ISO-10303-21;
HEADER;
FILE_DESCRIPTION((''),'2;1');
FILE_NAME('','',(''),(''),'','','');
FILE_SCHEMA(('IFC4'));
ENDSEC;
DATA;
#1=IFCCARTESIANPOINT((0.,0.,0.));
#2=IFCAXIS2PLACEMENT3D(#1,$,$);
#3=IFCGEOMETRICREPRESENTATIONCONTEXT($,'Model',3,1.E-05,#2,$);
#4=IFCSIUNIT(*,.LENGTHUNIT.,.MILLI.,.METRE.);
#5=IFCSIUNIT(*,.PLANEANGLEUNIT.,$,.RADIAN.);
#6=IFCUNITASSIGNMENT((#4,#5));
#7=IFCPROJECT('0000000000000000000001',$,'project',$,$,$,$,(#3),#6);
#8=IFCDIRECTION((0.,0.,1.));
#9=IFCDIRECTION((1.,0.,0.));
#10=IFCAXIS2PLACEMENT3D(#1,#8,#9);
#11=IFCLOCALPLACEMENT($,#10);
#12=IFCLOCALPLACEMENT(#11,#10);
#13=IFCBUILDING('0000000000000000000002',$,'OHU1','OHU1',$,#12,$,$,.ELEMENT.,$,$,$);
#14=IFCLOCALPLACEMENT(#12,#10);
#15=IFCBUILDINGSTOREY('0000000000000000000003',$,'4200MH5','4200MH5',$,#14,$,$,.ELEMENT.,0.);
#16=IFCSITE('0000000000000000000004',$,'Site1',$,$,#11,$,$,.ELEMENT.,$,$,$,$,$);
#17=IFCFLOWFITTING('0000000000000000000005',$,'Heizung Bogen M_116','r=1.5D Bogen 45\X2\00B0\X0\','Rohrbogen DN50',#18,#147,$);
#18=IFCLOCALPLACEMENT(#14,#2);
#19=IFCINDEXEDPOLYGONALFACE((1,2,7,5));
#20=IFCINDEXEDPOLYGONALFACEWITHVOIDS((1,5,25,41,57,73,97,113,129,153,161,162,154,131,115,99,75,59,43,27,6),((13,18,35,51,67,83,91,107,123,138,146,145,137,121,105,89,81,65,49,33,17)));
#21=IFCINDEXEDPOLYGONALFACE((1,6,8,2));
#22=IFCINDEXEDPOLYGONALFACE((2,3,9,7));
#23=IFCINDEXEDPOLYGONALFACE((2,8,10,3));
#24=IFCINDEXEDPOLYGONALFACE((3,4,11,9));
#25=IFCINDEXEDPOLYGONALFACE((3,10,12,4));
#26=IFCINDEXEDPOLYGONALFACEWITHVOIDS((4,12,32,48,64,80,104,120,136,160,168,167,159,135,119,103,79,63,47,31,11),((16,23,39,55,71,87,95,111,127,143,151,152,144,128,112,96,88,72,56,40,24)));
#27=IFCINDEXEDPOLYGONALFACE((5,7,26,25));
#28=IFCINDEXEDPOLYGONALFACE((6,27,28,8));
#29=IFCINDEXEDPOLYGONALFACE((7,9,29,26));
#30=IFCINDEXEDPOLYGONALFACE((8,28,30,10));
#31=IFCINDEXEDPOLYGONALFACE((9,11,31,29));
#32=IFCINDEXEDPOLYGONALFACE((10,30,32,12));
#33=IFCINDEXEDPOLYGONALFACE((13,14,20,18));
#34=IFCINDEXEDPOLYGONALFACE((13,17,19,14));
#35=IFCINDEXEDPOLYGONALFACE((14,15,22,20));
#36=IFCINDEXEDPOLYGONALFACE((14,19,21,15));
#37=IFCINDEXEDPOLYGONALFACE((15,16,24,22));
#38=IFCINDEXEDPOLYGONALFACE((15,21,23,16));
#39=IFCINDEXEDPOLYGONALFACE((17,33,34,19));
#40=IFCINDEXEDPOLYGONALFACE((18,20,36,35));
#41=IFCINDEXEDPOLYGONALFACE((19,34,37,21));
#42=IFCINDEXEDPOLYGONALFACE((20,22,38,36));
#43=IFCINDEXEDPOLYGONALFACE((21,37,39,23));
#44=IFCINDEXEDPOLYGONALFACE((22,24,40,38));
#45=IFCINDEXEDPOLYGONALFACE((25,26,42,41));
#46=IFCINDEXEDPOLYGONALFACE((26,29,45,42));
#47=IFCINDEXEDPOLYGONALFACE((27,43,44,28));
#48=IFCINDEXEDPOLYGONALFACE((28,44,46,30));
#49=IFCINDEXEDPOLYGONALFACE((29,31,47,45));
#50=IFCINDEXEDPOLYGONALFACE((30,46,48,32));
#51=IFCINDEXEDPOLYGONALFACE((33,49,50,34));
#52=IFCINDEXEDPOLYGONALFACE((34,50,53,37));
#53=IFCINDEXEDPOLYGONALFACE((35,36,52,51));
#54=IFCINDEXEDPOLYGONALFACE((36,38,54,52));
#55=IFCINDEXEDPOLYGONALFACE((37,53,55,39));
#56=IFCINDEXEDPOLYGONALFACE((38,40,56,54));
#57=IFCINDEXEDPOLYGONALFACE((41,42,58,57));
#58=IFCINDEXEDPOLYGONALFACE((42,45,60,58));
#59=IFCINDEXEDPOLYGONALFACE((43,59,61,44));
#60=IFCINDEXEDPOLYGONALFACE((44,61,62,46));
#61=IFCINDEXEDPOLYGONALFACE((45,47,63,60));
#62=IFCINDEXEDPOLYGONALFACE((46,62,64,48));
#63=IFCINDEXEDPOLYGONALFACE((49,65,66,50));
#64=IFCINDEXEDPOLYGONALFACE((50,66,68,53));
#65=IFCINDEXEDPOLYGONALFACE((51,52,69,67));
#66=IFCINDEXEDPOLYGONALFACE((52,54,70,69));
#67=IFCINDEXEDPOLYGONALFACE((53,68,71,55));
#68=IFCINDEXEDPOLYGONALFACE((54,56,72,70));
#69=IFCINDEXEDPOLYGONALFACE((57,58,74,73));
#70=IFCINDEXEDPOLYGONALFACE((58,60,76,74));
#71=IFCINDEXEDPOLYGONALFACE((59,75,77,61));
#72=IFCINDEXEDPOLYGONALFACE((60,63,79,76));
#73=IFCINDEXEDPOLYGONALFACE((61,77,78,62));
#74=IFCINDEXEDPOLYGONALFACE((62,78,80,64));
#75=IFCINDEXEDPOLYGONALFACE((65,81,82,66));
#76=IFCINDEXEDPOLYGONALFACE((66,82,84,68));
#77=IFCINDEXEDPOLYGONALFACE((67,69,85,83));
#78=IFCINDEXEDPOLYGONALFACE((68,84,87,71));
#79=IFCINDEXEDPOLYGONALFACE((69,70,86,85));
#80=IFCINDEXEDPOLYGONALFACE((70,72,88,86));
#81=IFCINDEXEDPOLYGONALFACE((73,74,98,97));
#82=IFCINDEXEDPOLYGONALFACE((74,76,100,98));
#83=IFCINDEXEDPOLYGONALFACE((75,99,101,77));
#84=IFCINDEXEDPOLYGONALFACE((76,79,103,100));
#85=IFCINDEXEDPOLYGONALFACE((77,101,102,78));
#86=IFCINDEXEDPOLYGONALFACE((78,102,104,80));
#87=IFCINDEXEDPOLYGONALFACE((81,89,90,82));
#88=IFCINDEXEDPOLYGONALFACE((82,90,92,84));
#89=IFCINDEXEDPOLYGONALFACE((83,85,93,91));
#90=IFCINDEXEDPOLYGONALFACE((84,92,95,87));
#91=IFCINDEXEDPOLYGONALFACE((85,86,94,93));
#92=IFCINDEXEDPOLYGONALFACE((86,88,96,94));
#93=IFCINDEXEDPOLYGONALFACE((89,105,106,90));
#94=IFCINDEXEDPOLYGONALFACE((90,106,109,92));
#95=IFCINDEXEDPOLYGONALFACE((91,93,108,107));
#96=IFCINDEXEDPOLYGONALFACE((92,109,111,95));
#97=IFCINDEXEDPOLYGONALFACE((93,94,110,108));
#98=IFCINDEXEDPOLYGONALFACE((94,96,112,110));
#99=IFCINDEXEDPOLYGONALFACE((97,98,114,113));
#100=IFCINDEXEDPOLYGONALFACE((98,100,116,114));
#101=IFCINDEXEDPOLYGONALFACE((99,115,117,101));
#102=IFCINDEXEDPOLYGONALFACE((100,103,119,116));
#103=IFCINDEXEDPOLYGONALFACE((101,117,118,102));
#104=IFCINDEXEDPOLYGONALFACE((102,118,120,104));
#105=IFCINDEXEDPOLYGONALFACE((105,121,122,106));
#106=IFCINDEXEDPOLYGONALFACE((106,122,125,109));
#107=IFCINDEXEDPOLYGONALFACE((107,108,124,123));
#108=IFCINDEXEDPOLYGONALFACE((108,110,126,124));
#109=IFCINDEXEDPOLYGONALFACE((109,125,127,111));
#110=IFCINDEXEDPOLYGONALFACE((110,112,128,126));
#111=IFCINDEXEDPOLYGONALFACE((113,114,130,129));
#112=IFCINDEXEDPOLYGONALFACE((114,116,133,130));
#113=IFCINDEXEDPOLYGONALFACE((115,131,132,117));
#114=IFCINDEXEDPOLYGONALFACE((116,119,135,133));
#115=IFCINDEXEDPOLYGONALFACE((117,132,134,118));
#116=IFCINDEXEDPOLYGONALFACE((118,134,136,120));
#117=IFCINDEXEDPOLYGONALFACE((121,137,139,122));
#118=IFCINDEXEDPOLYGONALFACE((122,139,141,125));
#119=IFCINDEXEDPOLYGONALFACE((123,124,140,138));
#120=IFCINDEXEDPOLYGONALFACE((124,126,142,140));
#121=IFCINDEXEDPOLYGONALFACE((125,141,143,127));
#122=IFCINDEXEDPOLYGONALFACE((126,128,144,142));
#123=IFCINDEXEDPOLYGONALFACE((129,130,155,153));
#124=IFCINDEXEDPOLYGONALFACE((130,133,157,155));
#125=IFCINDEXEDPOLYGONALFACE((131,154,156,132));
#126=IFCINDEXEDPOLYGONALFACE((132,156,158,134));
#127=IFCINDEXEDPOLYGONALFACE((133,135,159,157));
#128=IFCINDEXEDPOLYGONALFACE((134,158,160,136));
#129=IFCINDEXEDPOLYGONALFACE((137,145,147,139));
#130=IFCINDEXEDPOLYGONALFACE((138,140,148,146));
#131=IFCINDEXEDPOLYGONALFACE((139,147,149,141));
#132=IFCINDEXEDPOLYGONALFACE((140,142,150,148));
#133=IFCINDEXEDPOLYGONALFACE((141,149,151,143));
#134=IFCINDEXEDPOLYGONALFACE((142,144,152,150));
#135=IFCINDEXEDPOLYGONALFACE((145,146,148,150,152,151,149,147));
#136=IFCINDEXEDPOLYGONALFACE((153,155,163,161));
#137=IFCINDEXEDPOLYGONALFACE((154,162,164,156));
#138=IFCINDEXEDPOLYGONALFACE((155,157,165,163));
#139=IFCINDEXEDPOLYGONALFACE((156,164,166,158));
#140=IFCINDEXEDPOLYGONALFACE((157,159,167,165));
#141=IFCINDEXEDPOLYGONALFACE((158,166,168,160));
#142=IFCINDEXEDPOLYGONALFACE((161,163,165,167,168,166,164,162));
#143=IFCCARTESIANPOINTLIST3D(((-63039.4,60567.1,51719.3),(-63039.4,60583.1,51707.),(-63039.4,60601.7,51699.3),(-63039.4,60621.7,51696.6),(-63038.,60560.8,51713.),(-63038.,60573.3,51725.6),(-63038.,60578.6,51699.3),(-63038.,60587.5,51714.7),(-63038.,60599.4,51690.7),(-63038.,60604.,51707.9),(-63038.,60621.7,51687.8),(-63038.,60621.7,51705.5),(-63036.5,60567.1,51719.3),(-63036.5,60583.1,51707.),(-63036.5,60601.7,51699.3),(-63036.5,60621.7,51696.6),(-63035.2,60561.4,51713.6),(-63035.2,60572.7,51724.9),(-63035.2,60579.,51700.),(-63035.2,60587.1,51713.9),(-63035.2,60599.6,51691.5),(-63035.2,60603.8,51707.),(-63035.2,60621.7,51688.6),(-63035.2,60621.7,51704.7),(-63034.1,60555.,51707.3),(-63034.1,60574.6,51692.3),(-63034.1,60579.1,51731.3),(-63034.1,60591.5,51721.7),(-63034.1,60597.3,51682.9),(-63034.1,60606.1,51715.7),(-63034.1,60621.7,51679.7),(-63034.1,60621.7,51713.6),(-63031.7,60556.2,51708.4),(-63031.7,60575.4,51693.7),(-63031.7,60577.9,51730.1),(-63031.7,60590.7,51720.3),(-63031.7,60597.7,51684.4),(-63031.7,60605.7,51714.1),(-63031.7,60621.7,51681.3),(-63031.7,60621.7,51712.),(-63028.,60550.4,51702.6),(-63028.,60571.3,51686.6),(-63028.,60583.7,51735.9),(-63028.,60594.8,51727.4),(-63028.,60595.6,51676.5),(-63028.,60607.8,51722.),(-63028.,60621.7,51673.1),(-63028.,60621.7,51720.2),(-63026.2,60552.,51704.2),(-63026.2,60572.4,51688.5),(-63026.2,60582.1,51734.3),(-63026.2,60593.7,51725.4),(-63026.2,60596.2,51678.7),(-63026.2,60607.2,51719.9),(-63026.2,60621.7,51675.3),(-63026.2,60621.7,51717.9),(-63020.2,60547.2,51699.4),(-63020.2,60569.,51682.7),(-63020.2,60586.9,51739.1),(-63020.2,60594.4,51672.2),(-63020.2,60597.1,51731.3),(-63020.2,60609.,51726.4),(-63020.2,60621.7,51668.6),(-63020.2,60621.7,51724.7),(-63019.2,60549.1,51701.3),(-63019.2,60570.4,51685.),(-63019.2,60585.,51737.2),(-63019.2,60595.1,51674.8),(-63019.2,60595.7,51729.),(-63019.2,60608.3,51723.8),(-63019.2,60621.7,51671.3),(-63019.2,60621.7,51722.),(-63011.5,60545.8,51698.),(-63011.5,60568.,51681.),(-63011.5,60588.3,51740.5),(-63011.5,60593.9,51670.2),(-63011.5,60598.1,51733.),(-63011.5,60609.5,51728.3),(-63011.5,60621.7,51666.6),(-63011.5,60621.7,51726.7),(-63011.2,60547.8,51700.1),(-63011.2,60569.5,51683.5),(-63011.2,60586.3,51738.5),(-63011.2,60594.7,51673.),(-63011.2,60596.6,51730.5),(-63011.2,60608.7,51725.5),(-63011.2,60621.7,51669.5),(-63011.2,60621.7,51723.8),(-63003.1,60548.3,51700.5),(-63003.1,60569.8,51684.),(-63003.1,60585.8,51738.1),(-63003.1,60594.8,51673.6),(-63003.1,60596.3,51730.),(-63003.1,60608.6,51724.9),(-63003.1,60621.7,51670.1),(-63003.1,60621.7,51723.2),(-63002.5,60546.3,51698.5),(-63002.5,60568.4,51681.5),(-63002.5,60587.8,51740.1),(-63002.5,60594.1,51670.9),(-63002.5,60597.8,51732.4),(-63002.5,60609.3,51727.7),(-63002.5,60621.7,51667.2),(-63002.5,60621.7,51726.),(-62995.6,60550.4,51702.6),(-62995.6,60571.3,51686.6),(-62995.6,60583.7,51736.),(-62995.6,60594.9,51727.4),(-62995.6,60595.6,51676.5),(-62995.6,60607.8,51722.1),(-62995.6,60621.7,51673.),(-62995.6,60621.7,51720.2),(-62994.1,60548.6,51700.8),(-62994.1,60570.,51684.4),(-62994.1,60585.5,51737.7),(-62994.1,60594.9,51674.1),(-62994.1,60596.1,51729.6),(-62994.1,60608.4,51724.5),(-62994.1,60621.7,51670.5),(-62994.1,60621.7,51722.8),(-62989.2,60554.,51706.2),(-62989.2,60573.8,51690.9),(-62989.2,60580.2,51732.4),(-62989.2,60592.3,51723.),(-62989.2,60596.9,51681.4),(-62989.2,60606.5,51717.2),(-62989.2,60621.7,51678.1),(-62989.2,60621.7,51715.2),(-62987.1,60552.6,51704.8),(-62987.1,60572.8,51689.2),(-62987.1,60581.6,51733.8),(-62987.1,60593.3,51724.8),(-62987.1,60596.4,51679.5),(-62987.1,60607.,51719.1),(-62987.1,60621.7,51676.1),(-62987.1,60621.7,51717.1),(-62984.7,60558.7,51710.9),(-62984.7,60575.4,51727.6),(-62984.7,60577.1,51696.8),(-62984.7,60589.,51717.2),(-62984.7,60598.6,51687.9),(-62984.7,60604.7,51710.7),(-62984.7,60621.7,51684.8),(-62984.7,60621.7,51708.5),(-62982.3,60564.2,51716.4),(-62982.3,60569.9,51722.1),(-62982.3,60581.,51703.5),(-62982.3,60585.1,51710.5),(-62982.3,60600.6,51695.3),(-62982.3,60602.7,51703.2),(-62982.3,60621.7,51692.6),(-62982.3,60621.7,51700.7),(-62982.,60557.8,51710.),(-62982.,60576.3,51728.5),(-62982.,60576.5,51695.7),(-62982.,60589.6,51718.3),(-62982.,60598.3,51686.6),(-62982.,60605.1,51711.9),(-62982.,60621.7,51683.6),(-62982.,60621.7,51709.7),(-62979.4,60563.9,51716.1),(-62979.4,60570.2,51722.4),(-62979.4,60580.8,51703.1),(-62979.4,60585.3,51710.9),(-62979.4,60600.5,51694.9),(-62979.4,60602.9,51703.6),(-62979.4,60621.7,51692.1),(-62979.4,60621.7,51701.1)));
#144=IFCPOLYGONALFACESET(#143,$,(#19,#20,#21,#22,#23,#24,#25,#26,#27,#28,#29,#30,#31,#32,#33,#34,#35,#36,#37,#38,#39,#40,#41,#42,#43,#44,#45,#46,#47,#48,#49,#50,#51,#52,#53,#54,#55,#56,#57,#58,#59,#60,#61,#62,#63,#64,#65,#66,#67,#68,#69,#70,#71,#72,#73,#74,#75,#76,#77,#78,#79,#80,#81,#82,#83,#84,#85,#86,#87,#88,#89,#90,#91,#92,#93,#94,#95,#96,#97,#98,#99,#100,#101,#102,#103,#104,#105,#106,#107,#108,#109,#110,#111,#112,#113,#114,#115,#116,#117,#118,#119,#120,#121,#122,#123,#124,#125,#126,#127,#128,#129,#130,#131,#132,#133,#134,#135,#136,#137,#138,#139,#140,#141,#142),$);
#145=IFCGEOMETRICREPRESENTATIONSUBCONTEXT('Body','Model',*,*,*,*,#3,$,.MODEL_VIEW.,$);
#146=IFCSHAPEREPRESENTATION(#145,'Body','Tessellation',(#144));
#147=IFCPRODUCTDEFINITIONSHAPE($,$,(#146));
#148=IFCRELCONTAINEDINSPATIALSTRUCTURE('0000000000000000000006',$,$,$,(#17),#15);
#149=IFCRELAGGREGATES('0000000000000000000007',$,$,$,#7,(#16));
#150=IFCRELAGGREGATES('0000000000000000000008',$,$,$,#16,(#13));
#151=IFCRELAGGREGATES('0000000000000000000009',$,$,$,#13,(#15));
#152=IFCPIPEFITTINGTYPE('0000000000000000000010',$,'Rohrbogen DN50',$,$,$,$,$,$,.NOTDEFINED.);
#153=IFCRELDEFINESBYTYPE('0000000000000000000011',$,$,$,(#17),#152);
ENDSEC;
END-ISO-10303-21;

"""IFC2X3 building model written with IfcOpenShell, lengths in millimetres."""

from ifc_helpers import new_model, entity, si_unit, frame, origin, origin_with_axes, place, context, subcontext, project, spatial, type_object, element, save


model = new_model("IFC2X3")

# Units and contexts
model_context = context("Model", 3, precision=1e-05, world=origin())
body_context = subcontext(model_context, "Body", "Model", "MODEL_VIEW")
ifc_project = project(units=[si_unit("LENGTHUNIT", "METRE", prefix="MILLI"), si_unit("PLANEANGLEUNIT", "RADIAN")], contexts=[model_context])

# Site, building, storey
site_placement = place(None, origin_with_axes())
site = spatial("IfcSite", under=ifc_project, at=site_placement, Name="Site1", CompositionType="ELEMENT")
building_placement = place(site_placement, origin_with_axes())
building = spatial("IfcBuilding", under=site, at=building_placement, Name="OHU1", Description="OHU1", CompositionType="ELEMENT")
storey_placement = place(building_placement, origin_with_axes())
storey = spatial("IfcBuildingStorey", under=building, at=storey_placement, Name="4200MH5", Description="4200MH5", CompositionType="ELEMENT", Elevation=0.0)

# Flow fitting
pipe_fitting_type_1 = type_object("IfcPipeFittingType", Name="Rohrbogen DN50", PredefinedType="NOTDEFINED")
flow_fitting_1_placement = place(storey_placement, frame((-63009.2, 60604.5, 51681.8), z_axis=(0.0, 0.0, 1.0), x_axis=(1.0, 0.0, 0.0)))
element("IfcFlowFitting", 1, at=flow_fitting_1_placement, inside=storey, type_object=pipe_fitting_type_1, Name="Heizung Bogen M_116", Description="r=1.5D Bogen 45°", ObjectType="Rohrbogen DN50", context=body_context, shape_type="SweptSolid", body=[
    entity("IfcRevolvedAreaSolid", entity("IfcCircleHollowProfileDef", "AREA", None, entity("IfcAxis2Placement2D", entity("IfcCartesianPoint", [0.0, 0.0]), entity("IfcDirection", [1.0, 0.0])), 30.1, 2.9), entity("IfcAxis2Placement3D", entity("IfcCartesianPoint", [0.0, -37.4, 37.4]), entity("IfcDirection", [0.000002, 0.707107, -0.707107]), entity("IfcDirection", [-1.0, 0.000003, 0.0])), entity("IfcAxis1Placement", entity("IfcCartesianPoint", [0.0, 77.3, 0.0]), entity("IfcDirection", [-1.0, 0.0, 0.0])), 0.785398),
])

save(model, "model.ifc")
